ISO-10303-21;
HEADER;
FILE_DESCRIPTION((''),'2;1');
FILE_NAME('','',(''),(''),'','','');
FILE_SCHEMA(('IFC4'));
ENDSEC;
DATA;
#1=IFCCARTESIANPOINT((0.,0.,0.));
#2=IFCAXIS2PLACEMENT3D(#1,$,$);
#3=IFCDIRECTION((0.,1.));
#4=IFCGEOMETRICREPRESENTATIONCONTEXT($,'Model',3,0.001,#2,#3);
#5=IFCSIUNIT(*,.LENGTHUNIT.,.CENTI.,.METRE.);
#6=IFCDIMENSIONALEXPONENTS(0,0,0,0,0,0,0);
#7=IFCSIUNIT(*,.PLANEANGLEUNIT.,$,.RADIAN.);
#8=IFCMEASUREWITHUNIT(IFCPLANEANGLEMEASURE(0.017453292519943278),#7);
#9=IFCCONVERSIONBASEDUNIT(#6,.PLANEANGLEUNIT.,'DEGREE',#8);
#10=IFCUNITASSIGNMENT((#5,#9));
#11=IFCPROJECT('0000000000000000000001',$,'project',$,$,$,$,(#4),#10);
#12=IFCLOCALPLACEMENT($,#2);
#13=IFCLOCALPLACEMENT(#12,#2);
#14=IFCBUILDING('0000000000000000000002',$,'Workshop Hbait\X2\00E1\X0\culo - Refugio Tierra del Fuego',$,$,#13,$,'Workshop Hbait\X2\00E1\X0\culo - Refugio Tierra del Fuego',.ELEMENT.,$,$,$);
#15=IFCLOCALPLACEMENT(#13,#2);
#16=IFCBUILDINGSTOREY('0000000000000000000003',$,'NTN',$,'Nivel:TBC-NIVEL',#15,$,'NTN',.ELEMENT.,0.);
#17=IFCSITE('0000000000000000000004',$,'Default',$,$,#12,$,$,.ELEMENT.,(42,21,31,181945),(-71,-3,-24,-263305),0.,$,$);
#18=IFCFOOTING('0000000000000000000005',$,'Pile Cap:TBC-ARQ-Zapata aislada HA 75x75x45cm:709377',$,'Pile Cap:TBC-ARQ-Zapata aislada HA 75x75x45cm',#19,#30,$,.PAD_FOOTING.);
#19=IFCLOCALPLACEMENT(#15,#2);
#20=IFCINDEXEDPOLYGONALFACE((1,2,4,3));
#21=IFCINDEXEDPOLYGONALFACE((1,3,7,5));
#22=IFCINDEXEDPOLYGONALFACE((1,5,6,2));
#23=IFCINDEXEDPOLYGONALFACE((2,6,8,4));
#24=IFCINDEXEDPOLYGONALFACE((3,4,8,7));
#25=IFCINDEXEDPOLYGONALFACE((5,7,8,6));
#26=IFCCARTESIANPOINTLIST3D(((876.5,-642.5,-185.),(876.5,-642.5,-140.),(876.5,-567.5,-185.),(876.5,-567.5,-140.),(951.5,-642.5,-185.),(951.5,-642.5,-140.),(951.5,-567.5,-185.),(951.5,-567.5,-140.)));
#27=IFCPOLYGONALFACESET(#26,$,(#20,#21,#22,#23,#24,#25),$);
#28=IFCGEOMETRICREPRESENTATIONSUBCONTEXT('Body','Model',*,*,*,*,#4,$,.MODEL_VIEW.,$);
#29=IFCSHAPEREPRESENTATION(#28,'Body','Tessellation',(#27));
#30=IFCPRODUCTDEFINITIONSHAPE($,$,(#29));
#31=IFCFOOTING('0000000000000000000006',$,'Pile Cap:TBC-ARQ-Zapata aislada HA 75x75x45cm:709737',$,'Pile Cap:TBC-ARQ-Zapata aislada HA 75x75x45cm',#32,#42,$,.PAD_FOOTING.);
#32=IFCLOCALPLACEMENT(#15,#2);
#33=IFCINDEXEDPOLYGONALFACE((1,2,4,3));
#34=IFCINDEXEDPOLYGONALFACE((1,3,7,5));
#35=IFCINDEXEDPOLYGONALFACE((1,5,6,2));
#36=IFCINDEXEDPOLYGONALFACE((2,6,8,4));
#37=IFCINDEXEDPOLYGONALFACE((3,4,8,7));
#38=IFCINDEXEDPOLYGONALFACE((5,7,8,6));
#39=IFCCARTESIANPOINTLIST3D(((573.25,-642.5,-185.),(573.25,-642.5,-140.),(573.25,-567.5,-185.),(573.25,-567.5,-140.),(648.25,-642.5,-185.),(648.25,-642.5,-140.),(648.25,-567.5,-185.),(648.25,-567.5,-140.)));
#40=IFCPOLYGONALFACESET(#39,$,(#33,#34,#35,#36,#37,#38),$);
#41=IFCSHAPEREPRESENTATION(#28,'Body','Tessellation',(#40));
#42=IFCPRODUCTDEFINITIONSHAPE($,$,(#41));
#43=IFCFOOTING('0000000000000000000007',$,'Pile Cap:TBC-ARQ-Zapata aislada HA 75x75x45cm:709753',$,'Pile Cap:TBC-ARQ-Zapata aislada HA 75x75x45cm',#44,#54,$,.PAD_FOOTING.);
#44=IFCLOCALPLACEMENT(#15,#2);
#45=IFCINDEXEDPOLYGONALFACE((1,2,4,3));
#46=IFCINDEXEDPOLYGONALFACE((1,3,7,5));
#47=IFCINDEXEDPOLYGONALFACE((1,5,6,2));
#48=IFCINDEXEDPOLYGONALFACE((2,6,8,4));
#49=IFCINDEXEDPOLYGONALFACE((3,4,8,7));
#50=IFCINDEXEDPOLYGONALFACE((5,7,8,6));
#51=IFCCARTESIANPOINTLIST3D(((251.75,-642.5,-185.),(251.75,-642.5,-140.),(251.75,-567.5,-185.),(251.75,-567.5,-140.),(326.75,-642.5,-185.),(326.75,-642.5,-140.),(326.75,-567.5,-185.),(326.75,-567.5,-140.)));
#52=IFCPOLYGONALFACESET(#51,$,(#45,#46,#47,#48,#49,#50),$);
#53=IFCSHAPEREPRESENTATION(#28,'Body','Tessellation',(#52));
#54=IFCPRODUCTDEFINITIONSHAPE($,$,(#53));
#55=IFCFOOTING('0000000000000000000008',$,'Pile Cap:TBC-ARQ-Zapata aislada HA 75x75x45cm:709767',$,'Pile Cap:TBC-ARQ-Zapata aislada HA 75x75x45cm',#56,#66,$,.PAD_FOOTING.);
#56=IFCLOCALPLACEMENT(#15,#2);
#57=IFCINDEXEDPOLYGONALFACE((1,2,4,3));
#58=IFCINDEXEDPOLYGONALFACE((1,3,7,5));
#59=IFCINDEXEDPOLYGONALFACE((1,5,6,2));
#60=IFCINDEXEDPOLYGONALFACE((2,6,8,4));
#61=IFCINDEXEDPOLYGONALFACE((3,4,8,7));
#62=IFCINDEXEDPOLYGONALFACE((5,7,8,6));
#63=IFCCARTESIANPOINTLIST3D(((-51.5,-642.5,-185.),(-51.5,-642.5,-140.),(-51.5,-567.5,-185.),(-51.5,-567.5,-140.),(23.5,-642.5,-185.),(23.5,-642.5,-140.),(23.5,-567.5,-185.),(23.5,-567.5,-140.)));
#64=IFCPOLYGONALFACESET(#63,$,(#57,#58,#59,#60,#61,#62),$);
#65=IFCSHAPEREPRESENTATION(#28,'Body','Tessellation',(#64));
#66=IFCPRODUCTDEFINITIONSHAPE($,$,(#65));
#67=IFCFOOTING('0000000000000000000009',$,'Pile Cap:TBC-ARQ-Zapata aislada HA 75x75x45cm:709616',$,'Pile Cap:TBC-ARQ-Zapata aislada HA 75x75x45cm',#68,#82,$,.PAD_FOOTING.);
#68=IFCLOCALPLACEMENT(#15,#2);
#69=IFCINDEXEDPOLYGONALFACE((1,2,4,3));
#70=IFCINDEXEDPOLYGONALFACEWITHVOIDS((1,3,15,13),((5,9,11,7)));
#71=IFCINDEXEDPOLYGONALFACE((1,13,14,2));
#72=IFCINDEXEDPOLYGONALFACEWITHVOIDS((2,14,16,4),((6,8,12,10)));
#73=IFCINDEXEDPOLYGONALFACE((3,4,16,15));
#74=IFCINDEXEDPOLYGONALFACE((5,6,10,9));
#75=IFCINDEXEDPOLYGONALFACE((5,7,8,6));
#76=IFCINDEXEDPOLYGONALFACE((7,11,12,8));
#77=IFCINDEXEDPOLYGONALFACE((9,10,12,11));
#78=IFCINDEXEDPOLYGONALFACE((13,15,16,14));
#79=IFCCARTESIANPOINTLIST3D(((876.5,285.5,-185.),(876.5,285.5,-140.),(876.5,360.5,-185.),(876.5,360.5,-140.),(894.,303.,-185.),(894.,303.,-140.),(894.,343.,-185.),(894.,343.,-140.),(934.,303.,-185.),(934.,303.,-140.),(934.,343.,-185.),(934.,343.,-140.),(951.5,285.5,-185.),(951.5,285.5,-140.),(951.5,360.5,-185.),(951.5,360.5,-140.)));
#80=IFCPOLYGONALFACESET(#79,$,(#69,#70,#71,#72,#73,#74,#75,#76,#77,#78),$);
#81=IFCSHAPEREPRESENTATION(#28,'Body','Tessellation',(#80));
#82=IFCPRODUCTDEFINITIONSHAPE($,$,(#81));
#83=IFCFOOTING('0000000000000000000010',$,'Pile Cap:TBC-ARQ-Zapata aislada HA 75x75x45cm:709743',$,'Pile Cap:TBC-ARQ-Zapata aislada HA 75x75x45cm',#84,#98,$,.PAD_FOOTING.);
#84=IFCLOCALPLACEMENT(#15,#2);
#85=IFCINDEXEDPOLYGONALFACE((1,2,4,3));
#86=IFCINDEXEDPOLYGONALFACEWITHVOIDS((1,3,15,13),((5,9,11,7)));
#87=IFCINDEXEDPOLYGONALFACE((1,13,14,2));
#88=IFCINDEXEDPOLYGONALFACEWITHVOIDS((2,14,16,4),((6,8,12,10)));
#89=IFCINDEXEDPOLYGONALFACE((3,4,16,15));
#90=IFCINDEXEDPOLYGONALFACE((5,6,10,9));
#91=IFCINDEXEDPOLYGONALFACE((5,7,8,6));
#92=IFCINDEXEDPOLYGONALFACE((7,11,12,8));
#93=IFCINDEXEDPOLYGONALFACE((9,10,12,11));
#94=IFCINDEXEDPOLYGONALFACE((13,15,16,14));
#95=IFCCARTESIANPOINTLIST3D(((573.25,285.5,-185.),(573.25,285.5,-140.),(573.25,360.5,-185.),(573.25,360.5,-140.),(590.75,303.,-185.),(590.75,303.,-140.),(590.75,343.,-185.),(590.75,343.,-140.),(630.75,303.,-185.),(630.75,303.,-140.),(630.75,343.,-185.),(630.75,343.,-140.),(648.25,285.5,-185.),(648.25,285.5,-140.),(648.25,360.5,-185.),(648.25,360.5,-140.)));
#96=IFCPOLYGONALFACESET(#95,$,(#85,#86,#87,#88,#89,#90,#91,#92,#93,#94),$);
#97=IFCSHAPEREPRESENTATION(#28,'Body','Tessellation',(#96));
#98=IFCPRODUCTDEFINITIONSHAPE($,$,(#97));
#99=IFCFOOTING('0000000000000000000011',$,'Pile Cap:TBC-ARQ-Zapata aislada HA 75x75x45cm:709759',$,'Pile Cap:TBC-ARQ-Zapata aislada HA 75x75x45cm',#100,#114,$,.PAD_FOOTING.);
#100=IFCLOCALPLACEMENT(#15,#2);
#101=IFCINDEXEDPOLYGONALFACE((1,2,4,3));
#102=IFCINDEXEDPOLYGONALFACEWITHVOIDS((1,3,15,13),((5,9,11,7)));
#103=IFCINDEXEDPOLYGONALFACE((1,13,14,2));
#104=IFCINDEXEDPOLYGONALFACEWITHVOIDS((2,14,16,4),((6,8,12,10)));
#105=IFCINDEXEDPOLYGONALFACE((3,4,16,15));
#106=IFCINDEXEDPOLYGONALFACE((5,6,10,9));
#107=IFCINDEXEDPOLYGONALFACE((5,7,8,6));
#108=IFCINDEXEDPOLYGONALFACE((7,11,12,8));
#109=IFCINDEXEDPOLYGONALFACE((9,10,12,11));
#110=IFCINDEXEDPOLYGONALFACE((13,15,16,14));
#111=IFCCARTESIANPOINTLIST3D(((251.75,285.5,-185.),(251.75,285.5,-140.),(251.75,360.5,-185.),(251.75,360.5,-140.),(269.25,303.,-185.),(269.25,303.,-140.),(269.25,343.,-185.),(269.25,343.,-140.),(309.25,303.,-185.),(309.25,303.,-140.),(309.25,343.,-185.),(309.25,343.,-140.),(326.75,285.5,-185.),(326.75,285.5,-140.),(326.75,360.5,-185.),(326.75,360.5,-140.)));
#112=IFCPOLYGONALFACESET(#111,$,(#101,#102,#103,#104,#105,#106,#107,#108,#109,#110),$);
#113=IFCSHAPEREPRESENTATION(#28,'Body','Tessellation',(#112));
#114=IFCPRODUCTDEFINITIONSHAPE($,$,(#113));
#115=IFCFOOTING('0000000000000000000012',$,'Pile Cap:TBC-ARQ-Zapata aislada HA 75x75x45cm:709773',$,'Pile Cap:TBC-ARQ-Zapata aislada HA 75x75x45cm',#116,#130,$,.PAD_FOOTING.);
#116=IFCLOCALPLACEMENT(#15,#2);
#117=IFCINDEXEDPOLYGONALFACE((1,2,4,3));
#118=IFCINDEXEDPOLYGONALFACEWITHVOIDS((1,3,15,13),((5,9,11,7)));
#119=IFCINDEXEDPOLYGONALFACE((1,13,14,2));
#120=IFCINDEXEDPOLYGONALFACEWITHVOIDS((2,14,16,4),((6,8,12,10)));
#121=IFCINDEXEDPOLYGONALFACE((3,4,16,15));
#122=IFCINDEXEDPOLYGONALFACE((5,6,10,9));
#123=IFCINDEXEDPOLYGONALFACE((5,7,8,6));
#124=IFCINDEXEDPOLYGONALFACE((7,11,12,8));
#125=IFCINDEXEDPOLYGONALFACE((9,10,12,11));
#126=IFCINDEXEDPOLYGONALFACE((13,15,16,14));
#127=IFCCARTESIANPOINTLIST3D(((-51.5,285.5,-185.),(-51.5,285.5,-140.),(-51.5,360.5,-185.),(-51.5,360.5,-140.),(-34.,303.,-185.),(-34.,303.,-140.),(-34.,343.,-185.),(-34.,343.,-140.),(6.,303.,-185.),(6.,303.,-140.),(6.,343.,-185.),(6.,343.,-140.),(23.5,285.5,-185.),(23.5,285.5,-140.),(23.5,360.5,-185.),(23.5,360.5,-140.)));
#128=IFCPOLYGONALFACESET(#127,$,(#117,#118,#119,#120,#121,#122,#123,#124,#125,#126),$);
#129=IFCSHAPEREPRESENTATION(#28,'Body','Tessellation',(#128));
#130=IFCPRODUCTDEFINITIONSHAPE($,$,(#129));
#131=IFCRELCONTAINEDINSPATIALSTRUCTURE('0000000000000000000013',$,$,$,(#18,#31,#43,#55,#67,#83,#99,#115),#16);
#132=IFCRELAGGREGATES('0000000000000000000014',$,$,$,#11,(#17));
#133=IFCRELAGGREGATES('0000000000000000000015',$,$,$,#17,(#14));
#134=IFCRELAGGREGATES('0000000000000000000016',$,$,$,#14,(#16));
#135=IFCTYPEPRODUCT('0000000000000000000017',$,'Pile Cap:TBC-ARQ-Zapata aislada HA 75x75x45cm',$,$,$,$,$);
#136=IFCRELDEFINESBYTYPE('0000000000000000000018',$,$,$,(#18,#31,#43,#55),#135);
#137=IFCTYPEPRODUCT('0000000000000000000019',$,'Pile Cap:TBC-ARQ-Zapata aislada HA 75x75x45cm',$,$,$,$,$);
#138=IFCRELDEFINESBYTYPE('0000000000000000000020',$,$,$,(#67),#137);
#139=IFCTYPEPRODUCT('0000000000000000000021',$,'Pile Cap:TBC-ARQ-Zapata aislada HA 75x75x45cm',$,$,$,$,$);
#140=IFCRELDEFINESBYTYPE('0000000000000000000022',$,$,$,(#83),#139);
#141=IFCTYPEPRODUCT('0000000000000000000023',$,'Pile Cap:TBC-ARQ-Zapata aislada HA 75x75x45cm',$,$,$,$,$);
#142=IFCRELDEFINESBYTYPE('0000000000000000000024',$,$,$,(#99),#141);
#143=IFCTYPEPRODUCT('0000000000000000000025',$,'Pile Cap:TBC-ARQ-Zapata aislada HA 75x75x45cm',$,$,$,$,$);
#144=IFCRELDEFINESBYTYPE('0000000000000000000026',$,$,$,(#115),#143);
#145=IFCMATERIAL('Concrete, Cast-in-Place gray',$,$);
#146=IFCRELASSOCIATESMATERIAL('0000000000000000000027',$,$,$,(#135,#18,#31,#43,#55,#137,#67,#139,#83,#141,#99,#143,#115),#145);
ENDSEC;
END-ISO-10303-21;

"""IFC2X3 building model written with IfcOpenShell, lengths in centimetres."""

from ifc_helpers import new_model, entity, si_unit, converted_unit, direction, frame, origin, origin_2d_with_axis, place, context, subcontext, project, spatial, polyline, rectangle, outline, extrude, source, transform, mapped, material, type_object, type_shapes, element, save


model = new_model("IFC2X3")

# Units and contexts
model_context = context("Model", 3, precision=0.001, world=origin(), true_north=direction((0.0, 1.0)))
body_context = subcontext(model_context, "Body", "Model", "MODEL_VIEW")
ifc_project = project(units=[si_unit("LENGTHUNIT", "METRE", prefix="CENTI"), converted_unit("PLANEANGLEUNIT", "DEGREE", entity("IfcPlaneAngleMeasure", 0.017453292519943278), si_unit("PLANEANGLEUNIT", "RADIAN"), dimensions=[0, 0, 0, 0, 0, 0, 0])], contexts=[model_context])

# Site, building, storey
site_placement = place(None, origin())
site = spatial("IfcSite", under=ifc_project, at=site_placement, Name="Default", CompositionType="ELEMENT", RefLatitude=(42, 21, 31, 181945), RefLongitude=(-71, -3, -24, -263305), RefElevation=0.0)
building_placement = place(site_placement, origin())
building = spatial("IfcBuilding", under=site, at=building_placement, Name="Workshop Hbaitáculo - Refugio Tierra del Fuego", LongName="Workshop Hbaitáculo - Refugio Tierra del Fuego", CompositionType="ELEMENT")
storey_placement = place(building_placement, origin())
storey = spatial("IfcBuildingStorey", under=building, at=storey_placement, Name="NTN", ObjectType="Nivel:TBC-NIVEL", LongName="NTN", CompositionType="ELEMENT", Elevation=0.0)

# Footings
ifc_material = material(Name="Concrete, Cast-in-Place gray")
type_product_1 = type_object("IfcTypeProduct", Name="Pile Cap:TBC-ARQ-Zapata aislada HA 75x75x45cm", material=ifc_material)
shared_shape_1 = source(origin(), body_context, "Body", "SweptSolid", [
    extrude(rectangle(XDim=75.0, YDim=75.0, at=origin_2d_with_axis()), frame((0.0, 0.0, -45.0), z_axis=(0.0, 0.0, 1.0), x_axis=(-1.0, 0.0, 0.0)), (0.0, 0.0, 1.0), 45.0),
])
type_shapes(type_product_1, [shared_shape_1])
for number, where, name in (
    (1, (914.0, -605.0, -140.0), "Pile Cap:TBC-ARQ-Zapata aislada HA 75x75x45cm:709377"),
    (2, (610.75, -605.0, -140.0), "Pile Cap:TBC-ARQ-Zapata aislada HA 75x75x45cm:709737"),
    (3, (289.25, -605.0, -140.0), "Pile Cap:TBC-ARQ-Zapata aislada HA 75x75x45cm:709753"),
    (4, (-14.0, -605.0, -140.0), "Pile Cap:TBC-ARQ-Zapata aislada HA 75x75x45cm:709767"),
):
    element("IfcFooting", number, at=place(storey_placement, frame(where)), inside=storey, type_object=type_product_1, material=ifc_material, Name=name, ObjectType="Pile Cap:TBC-ARQ-Zapata aislada HA 75x75x45cm", PredefinedType="PAD_FOOTING", context=body_context, shape_type="MappedRepresentation", body=[
        mapped(shared_shape_1, transform((0.0, 0.0, 0.0), scale=1.0)),
    ])
type_product_2 = type_object("IfcTypeProduct", Name="Pile Cap:TBC-ARQ-Zapata aislada HA 75x75x45cm", material=ifc_material)
shared_shape_2 = source(origin(), body_context, "Body", "SweptSolid", [
    extrude(outline(polyline([(-37.5, -37.5), (37.5, -37.5), (37.5, 37.5), (-37.5, 37.5), (-37.5, -37.5)]), holes=[polyline([(-20.0, -20.0), (-20.0, 20.0), (20.0, 20.0), (20.0, -20.0), (-20.0, -20.0)])]), frame((914.0, 323.0, -185.0), z_axis=(0.0, 0.0, 1.0), x_axis=(-1.0, 0.0, 0.0)), (0.0, 0.0, 1.0), 45.0),
])
type_shapes(type_product_2, [shared_shape_2])
footing_1_placement = place(storey_placement, origin())
element("IfcFooting", 5, at=footing_1_placement, inside=storey, type_object=type_product_2, material=ifc_material, Name="Pile Cap:TBC-ARQ-Zapata aislada HA 75x75x45cm:709616", ObjectType="Pile Cap:TBC-ARQ-Zapata aislada HA 75x75x45cm", PredefinedType="PAD_FOOTING", context=body_context, shape_type="MappedRepresentation", body=[
    mapped(shared_shape_2, transform((0.0, 0.0, 0.0), scale=1.0)),
])
type_product_3 = type_object("IfcTypeProduct", Name="Pile Cap:TBC-ARQ-Zapata aislada HA 75x75x45cm", material=ifc_material)
shared_shape_3 = source(origin(), body_context, "Body", "SweptSolid", [
    extrude(outline(polyline([(-37.5, -37.5), (37.5, -37.5), (37.5, 37.5), (-37.5, 37.5), (-37.5, -37.5)]), holes=[polyline([(-20.0, -20.0), (-20.0, 20.0), (20.0, 20.0), (20.0, -20.0), (-20.0, -20.0)])]), frame((610.75, 323.0, -185.0), z_axis=(0.0, 0.0, 1.0), x_axis=(-1.0, 0.0, 0.0)), (0.0, 0.0, 1.0), 45.0),
])
type_shapes(type_product_3, [shared_shape_3])
footing_2_placement = place(storey_placement, origin())
element("IfcFooting", 6, at=footing_2_placement, inside=storey, type_object=type_product_3, material=ifc_material, Name="Pile Cap:TBC-ARQ-Zapata aislada HA 75x75x45cm:709743", ObjectType="Pile Cap:TBC-ARQ-Zapata aislada HA 75x75x45cm", PredefinedType="PAD_FOOTING", context=body_context, shape_type="MappedRepresentation", body=[
    mapped(shared_shape_3, transform((0.0, 0.0, 0.0), scale=1.0)),
])
type_product_4 = type_object("IfcTypeProduct", Name="Pile Cap:TBC-ARQ-Zapata aislada HA 75x75x45cm", material=ifc_material)
shared_shape_4 = source(origin(), body_context, "Body", "SweptSolid", [
    extrude(outline(polyline([(-37.5, -37.5), (37.5, -37.5), (37.5, 37.5), (-37.5, 37.5), (-37.5, -37.5)]), holes=[polyline([(-20.0, -20.0), (-20.0, 20.0), (20.0, 20.0), (20.0, -20.0), (-20.0, -20.0)])]), frame((289.25, 323.0, -185.0), z_axis=(0.0, 0.0, 1.0), x_axis=(-1.0, 0.0, 0.0)), (0.0, 0.0, 1.0), 45.0),
])
type_shapes(type_product_4, [shared_shape_4])
footing_3_placement = place(storey_placement, origin())
element("IfcFooting", 7, at=footing_3_placement, inside=storey, type_object=type_product_4, material=ifc_material, Name="Pile Cap:TBC-ARQ-Zapata aislada HA 75x75x45cm:709759", ObjectType="Pile Cap:TBC-ARQ-Zapata aislada HA 75x75x45cm", PredefinedType="PAD_FOOTING", context=body_context, shape_type="MappedRepresentation", body=[
    mapped(shared_shape_4, transform((0.0, 0.0, 0.0), scale=1.0)),
])
type_product_5 = type_object("IfcTypeProduct", Name="Pile Cap:TBC-ARQ-Zapata aislada HA 75x75x45cm", material=ifc_material)
shared_shape_5 = source(origin(), body_context, "Body", "SweptSolid", [
    extrude(outline(polyline([(-37.5, -37.5), (37.5, -37.5), (37.5, 37.5), (-37.5, 37.5), (-37.5, -37.5)]), holes=[polyline([(-20.0, -20.0), (-20.0, 20.0), (20.0, 20.0), (20.0, -20.0), (-20.0, -20.0)])]), frame((-14.0, 323.0, -185.0), z_axis=(0.0, 0.0, 1.0), x_axis=(-1.0, 0.0, 0.0)), (0.0, 0.0, 1.0), 45.0),
])
type_shapes(type_product_5, [shared_shape_5])
footing_4_placement = place(storey_placement, origin())
element("IfcFooting", 8, at=footing_4_placement, inside=storey, type_object=type_product_5, material=ifc_material, Name="Pile Cap:TBC-ARQ-Zapata aislada HA 75x75x45cm:709773", ObjectType="Pile Cap:TBC-ARQ-Zapata aislada HA 75x75x45cm", PredefinedType="PAD_FOOTING", context=body_context, shape_type="MappedRepresentation", body=[
    mapped(shared_shape_5, transform((0.0, 0.0, 0.0), scale=1.0)),
])

save(model, "model.ifc")
